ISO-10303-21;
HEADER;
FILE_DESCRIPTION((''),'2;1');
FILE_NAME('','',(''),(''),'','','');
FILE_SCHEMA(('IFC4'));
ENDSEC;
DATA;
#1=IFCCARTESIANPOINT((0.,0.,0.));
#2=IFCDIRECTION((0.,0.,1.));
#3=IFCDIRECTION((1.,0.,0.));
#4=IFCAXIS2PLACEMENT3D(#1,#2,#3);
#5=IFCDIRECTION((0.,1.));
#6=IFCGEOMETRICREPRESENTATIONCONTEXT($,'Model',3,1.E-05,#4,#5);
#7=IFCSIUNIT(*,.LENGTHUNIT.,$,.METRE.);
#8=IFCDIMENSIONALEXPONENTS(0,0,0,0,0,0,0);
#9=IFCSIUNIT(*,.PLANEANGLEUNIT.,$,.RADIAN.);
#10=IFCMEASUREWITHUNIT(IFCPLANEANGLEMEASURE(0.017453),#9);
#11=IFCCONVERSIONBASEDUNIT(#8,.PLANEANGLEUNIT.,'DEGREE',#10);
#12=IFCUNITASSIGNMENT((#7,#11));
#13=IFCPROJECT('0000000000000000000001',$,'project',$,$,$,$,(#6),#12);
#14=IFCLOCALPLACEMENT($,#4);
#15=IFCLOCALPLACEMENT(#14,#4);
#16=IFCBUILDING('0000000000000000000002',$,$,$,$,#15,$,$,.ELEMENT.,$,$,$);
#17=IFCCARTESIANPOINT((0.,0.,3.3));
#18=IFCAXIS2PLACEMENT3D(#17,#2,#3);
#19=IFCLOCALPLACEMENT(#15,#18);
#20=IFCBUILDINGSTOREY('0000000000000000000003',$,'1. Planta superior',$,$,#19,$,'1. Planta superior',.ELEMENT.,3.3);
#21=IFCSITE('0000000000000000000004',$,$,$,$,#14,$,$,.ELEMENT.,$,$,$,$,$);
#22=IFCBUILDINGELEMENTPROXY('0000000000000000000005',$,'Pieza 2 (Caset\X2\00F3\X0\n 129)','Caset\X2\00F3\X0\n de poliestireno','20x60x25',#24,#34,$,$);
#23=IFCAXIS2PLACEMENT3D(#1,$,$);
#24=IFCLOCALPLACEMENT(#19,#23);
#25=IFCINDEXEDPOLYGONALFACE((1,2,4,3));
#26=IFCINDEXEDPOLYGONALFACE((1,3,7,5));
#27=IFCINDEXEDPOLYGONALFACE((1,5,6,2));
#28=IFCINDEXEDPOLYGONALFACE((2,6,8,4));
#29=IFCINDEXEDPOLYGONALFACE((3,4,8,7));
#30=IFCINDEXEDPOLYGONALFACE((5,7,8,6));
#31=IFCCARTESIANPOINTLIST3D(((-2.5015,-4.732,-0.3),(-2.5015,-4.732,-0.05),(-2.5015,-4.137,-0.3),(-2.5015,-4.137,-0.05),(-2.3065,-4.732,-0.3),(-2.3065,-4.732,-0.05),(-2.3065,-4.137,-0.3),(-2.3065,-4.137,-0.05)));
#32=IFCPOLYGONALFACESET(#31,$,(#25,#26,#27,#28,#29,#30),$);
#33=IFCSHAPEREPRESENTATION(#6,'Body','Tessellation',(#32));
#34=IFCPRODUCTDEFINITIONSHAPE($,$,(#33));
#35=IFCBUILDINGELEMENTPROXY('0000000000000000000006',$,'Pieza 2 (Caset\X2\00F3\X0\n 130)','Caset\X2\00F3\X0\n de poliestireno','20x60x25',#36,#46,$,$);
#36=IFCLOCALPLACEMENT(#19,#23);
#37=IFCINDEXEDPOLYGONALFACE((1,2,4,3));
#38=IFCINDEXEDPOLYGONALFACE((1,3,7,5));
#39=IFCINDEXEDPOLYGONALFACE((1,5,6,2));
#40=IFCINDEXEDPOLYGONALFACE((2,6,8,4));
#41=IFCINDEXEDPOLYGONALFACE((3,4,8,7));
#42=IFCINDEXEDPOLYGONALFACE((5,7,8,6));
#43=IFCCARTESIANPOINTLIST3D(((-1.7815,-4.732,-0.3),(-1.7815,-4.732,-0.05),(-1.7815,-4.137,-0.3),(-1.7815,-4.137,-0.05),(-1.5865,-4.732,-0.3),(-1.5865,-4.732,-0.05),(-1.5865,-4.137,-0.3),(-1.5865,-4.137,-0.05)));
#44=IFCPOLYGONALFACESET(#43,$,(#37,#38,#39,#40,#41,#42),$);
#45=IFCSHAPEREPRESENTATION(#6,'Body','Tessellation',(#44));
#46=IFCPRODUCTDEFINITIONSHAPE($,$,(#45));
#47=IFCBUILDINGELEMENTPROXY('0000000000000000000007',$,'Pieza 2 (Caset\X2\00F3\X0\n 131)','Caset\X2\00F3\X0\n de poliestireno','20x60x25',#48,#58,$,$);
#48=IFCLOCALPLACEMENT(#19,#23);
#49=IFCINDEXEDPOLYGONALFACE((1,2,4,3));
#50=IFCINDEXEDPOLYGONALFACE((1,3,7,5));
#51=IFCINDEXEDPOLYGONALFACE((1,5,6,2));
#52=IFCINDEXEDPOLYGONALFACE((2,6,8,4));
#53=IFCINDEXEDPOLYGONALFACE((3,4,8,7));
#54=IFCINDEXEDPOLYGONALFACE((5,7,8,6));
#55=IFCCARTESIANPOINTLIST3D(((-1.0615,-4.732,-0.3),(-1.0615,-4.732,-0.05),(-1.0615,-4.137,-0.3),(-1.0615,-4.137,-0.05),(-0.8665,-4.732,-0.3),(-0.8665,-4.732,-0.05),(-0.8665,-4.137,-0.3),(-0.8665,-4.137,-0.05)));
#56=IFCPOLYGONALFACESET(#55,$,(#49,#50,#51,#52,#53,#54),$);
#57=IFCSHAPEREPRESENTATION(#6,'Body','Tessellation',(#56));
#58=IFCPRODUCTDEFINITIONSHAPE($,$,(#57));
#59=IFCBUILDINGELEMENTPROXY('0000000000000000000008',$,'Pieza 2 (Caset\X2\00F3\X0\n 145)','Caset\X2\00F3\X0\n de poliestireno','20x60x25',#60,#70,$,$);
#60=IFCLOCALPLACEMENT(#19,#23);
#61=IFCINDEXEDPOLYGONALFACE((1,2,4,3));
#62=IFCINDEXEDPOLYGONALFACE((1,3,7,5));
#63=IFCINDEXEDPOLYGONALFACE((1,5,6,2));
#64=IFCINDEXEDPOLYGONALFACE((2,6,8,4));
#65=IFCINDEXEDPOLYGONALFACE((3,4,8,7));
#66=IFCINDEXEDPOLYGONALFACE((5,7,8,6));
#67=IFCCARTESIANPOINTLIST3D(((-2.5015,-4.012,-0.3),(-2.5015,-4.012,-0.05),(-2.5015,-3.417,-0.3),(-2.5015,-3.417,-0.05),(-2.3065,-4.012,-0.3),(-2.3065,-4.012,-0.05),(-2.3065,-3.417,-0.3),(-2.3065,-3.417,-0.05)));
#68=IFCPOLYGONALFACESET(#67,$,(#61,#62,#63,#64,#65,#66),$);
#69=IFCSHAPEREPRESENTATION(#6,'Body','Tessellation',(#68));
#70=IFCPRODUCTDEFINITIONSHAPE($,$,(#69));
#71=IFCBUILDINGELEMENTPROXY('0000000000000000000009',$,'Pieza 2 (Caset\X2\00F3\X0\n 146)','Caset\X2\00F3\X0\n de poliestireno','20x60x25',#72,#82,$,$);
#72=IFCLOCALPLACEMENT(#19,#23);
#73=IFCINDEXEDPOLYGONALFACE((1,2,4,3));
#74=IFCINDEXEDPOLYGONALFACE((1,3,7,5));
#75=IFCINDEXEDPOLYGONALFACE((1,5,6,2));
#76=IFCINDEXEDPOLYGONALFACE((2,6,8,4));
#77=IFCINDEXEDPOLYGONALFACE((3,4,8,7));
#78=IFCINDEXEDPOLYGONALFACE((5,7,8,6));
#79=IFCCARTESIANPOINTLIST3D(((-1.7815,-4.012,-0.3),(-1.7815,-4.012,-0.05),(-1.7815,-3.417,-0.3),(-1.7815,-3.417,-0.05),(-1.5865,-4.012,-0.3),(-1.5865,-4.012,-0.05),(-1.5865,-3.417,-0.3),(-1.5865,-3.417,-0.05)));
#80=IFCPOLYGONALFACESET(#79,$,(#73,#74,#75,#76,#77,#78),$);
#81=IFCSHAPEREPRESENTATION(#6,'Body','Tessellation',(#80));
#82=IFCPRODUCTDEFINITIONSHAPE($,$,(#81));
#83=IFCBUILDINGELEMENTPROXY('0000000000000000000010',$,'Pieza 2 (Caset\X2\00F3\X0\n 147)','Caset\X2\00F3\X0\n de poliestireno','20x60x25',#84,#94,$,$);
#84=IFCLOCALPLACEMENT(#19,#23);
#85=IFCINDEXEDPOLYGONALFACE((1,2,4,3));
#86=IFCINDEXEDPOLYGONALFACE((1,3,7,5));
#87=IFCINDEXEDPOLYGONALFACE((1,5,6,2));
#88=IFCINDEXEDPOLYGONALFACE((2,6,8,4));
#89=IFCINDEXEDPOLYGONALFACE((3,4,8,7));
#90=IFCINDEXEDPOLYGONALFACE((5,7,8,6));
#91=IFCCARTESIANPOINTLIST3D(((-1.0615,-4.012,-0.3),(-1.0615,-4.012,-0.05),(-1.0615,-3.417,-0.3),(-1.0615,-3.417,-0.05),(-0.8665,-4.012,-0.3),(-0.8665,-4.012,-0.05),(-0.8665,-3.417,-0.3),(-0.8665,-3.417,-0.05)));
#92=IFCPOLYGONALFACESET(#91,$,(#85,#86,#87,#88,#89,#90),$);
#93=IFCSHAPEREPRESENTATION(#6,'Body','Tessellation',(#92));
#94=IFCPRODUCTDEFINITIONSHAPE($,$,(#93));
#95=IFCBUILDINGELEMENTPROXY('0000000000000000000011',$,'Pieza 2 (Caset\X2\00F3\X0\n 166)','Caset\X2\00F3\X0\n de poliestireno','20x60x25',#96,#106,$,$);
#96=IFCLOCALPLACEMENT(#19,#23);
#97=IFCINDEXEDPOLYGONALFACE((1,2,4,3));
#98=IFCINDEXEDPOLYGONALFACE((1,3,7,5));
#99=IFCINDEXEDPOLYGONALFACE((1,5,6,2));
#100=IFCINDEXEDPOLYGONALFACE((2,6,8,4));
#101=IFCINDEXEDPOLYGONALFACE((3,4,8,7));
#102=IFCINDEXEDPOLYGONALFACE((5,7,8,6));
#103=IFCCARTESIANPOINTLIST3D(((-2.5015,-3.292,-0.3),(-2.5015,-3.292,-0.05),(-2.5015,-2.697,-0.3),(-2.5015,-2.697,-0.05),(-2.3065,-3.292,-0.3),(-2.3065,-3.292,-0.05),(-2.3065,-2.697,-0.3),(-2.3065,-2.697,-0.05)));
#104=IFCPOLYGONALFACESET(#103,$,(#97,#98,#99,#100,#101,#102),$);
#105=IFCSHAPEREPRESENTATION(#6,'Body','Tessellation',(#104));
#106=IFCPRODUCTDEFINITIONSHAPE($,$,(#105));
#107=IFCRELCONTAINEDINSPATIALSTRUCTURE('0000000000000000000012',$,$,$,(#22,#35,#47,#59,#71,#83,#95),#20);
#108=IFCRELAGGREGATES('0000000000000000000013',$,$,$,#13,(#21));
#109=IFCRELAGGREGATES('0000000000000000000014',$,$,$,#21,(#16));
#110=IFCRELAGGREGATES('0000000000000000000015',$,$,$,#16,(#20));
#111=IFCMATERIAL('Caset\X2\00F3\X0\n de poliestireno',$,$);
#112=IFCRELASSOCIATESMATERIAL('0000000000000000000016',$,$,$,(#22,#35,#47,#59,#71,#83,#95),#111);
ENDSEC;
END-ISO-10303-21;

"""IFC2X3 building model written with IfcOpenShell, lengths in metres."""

from ifc_helpers import new_model, entity, si_unit, converted_unit, direction, frame, origin_with_axes, origin_2d_with_axis, place, context, project, spatial, rectangle, extrude, source, transform, mapped, material, element, save


model = new_model("IFC2X3")

# Units and contexts
model_context = context("Model", 3, precision=1e-05, world=origin_with_axes(), true_north=direction((0.0, 1.0)))
ifc_project = project(units=[si_unit("LENGTHUNIT", "METRE"), converted_unit("PLANEANGLEUNIT", "DEGREE", entity("IfcPlaneAngleMeasure", 0.017453), si_unit("PLANEANGLEUNIT", "RADIAN"), dimensions=[0, 0, 0, 0, 0, 0, 0])], contexts=[model_context])

# Site, building, storey
site_placement = place(None, origin_with_axes())
site = spatial("IfcSite", under=ifc_project, at=site_placement, CompositionType="ELEMENT")
building_placement = place(site_placement, origin_with_axes())
building = spatial("IfcBuilding", under=site, at=building_placement, CompositionType="ELEMENT")
storey_placement = place(building_placement, frame((0.0, 0.0, 3.3), z_axis=(0.0, 0.0, 1.0), x_axis=(1.0, 0.0, 0.0)))
storey = spatial("IfcBuildingStorey", under=building, at=storey_placement, Name="1. Planta superior", LongName="1. Planta superior", CompositionType="ELEMENT", Elevation=3.3)

# Building element proxies
ifc_material = material(Name="Casetón de poliestireno")
shared_shape = source(origin_with_axes(), model_context, "Body", "SweptSolid", [
    extrude(rectangle(XDim=0.195, YDim=0.25, at=origin_2d_with_axis()), origin_with_axes(), (0.0, 0.0, 1.0), 0.595),
])
placement_1 = place(storey_placement, frame((-2.404, -4.732, -0.175), z_axis=(0.0, 1.0, 0.0), x_axis=(-1.0, 0.0, 0.0)))
for number, where, z_axis, x_axis, name in (
    (1, (0.0, 0.0, 0.0), (0.0, 0.0, 1.0), (1.0, 0.0, 0.0), "Pieza 2 (Casetón 129)"),
):
    element("IfcBuildingElementProxy", number, at=place(placement_1, frame(where, z_axis=z_axis, x_axis=x_axis)), inside=storey, material=ifc_material, Name=name, Description="Casetón de poliestireno", ObjectType="20x60x25", context=model_context, shape_type="MappedRepresentation", body=[
        mapped(shared_shape, transform((0.0, 0.0, 0.0), x_axis=(1.0, 0.0, 0.0), y_axis=(0.0, 1.0, 0.0), z_axis=(0.0, 0.0, 1.0))),
    ])
placement_2 = place(storey_placement, frame((-1.684, -4.732, -0.175), z_axis=(0.0, 1.0, 0.0), x_axis=(-1.0, 0.0, 0.0)))
for number, where, z_axis, x_axis, name in (
    (2, (0.0, 0.0, 0.0), (0.0, 0.0, 1.0), (1.0, 0.0, 0.0), "Pieza 2 (Casetón 130)"),
):
    element("IfcBuildingElementProxy", number, at=place(placement_2, frame(where, z_axis=z_axis, x_axis=x_axis)), inside=storey, material=ifc_material, Name=name, Description="Casetón de poliestireno", ObjectType="20x60x25", context=model_context, shape_type="MappedRepresentation", body=[
        mapped(shared_shape, transform((0.0, 0.0, 0.0), x_axis=(1.0, 0.0, 0.0), y_axis=(0.0, 1.0, 0.0), z_axis=(0.0, 0.0, 1.0))),
    ])
placement_3 = place(storey_placement, frame((-0.964, -4.732, -0.175), z_axis=(0.0, 1.0, 0.0), x_axis=(-1.0, 0.0, 0.0)))
for number, where, z_axis, x_axis, name in (
    (3, (0.0, 0.0, 0.0), (0.0, 0.0, 1.0), (1.0, 0.0, 0.0), "Pieza 2 (Casetón 131)"),
):
    element("IfcBuildingElementProxy", number, at=place(placement_3, frame(where, z_axis=z_axis, x_axis=x_axis)), inside=storey, material=ifc_material, Name=name, Description="Casetón de poliestireno", ObjectType="20x60x25", context=model_context, shape_type="MappedRepresentation", body=[
        mapped(shared_shape, transform((0.0, 0.0, 0.0), x_axis=(1.0, 0.0, 0.0), y_axis=(0.0, 1.0, 0.0), z_axis=(0.0, 0.0, 1.0))),
    ])
placement_4 = place(storey_placement, frame((-2.404, -4.012, -0.175), z_axis=(0.0, 1.0, 0.0), x_axis=(-1.0, 0.0, 0.0)))
for number, where, z_axis, x_axis, name in (
    (4, (0.0, 0.0, 0.0), (0.0, 0.0, 1.0), (1.0, 0.0, 0.0), "Pieza 2 (Casetón 145)"),
):
    element("IfcBuildingElementProxy", number, at=place(placement_4, frame(where, z_axis=z_axis, x_axis=x_axis)), inside=storey, material=ifc_material, Name=name, Description="Casetón de poliestireno", ObjectType="20x60x25", context=model_context, shape_type="MappedRepresentation", body=[
        mapped(shared_shape, transform((0.0, 0.0, 0.0), x_axis=(1.0, 0.0, 0.0), y_axis=(0.0, 1.0, 0.0), z_axis=(0.0, 0.0, 1.0))),
    ])
placement_5 = place(storey_placement, frame((-1.684, -4.012, -0.175), z_axis=(0.0, 1.0, 0.0), x_axis=(-1.0, 0.0, 0.0)))
for number, where, z_axis, x_axis, name in (
    (5, (0.0, 0.0, 0.0), (0.0, 0.0, 1.0), (1.0, 0.0, 0.0), "Pieza 2 (Casetón 146)"),
):
    element("IfcBuildingElementProxy", number, at=place(placement_5, frame(where, z_axis=z_axis, x_axis=x_axis)), inside=storey, material=ifc_material, Name=name, Description="Casetón de poliestireno", ObjectType="20x60x25", context=model_context, shape_type="MappedRepresentation", body=[
        mapped(shared_shape, transform((0.0, 0.0, 0.0), x_axis=(1.0, 0.0, 0.0), y_axis=(0.0, 1.0, 0.0), z_axis=(0.0, 0.0, 1.0))),
    ])
placement_6 = place(storey_placement, frame((-0.964, -4.012, -0.175), z_axis=(0.0, 1.0, 0.0), x_axis=(-1.0, 0.0, 0.0)))
for number, where, z_axis, x_axis, name in (
    (6, (0.0, 0.0, 0.0), (0.0, 0.0, 1.0), (1.0, 0.0, 0.0), "Pieza 2 (Casetón 147)"),
):
    element("IfcBuildingElementProxy", number, at=place(placement_6, frame(where, z_axis=z_axis, x_axis=x_axis)), inside=storey, material=ifc_material, Name=name, Description="Casetón de poliestireno", ObjectType="20x60x25", context=model_context, shape_type="MappedRepresentation", body=[
        mapped(shared_shape, transform((0.0, 0.0, 0.0), x_axis=(1.0, 0.0, 0.0), y_axis=(0.0, 1.0, 0.0), z_axis=(0.0, 0.0, 1.0))),
    ])
placement_7 = place(storey_placement, frame((-2.404, -3.292, -0.175), z_axis=(0.0, 1.0, 0.0), x_axis=(-1.0, 0.0, 0.0)))
for number, where, z_axis, x_axis, name in (
    (7, (0.0, 0.0, 0.0), (0.0, 0.0, 1.0), (1.0, 0.0, 0.0), "Pieza 2 (Casetón 166)"),
):
    element("IfcBuildingElementProxy", number, at=place(placement_7, frame(where, z_axis=z_axis, x_axis=x_axis)), inside=storey, material=ifc_material, Name=name, Description="Casetón de poliestireno", ObjectType="20x60x25", context=model_context, shape_type="MappedRepresentation", body=[
        mapped(shared_shape, transform((0.0, 0.0, 0.0), x_axis=(1.0, 0.0, 0.0), y_axis=(0.0, 1.0, 0.0), z_axis=(0.0, 0.0, 1.0))),
    ])

save(model, "model.ifc")
